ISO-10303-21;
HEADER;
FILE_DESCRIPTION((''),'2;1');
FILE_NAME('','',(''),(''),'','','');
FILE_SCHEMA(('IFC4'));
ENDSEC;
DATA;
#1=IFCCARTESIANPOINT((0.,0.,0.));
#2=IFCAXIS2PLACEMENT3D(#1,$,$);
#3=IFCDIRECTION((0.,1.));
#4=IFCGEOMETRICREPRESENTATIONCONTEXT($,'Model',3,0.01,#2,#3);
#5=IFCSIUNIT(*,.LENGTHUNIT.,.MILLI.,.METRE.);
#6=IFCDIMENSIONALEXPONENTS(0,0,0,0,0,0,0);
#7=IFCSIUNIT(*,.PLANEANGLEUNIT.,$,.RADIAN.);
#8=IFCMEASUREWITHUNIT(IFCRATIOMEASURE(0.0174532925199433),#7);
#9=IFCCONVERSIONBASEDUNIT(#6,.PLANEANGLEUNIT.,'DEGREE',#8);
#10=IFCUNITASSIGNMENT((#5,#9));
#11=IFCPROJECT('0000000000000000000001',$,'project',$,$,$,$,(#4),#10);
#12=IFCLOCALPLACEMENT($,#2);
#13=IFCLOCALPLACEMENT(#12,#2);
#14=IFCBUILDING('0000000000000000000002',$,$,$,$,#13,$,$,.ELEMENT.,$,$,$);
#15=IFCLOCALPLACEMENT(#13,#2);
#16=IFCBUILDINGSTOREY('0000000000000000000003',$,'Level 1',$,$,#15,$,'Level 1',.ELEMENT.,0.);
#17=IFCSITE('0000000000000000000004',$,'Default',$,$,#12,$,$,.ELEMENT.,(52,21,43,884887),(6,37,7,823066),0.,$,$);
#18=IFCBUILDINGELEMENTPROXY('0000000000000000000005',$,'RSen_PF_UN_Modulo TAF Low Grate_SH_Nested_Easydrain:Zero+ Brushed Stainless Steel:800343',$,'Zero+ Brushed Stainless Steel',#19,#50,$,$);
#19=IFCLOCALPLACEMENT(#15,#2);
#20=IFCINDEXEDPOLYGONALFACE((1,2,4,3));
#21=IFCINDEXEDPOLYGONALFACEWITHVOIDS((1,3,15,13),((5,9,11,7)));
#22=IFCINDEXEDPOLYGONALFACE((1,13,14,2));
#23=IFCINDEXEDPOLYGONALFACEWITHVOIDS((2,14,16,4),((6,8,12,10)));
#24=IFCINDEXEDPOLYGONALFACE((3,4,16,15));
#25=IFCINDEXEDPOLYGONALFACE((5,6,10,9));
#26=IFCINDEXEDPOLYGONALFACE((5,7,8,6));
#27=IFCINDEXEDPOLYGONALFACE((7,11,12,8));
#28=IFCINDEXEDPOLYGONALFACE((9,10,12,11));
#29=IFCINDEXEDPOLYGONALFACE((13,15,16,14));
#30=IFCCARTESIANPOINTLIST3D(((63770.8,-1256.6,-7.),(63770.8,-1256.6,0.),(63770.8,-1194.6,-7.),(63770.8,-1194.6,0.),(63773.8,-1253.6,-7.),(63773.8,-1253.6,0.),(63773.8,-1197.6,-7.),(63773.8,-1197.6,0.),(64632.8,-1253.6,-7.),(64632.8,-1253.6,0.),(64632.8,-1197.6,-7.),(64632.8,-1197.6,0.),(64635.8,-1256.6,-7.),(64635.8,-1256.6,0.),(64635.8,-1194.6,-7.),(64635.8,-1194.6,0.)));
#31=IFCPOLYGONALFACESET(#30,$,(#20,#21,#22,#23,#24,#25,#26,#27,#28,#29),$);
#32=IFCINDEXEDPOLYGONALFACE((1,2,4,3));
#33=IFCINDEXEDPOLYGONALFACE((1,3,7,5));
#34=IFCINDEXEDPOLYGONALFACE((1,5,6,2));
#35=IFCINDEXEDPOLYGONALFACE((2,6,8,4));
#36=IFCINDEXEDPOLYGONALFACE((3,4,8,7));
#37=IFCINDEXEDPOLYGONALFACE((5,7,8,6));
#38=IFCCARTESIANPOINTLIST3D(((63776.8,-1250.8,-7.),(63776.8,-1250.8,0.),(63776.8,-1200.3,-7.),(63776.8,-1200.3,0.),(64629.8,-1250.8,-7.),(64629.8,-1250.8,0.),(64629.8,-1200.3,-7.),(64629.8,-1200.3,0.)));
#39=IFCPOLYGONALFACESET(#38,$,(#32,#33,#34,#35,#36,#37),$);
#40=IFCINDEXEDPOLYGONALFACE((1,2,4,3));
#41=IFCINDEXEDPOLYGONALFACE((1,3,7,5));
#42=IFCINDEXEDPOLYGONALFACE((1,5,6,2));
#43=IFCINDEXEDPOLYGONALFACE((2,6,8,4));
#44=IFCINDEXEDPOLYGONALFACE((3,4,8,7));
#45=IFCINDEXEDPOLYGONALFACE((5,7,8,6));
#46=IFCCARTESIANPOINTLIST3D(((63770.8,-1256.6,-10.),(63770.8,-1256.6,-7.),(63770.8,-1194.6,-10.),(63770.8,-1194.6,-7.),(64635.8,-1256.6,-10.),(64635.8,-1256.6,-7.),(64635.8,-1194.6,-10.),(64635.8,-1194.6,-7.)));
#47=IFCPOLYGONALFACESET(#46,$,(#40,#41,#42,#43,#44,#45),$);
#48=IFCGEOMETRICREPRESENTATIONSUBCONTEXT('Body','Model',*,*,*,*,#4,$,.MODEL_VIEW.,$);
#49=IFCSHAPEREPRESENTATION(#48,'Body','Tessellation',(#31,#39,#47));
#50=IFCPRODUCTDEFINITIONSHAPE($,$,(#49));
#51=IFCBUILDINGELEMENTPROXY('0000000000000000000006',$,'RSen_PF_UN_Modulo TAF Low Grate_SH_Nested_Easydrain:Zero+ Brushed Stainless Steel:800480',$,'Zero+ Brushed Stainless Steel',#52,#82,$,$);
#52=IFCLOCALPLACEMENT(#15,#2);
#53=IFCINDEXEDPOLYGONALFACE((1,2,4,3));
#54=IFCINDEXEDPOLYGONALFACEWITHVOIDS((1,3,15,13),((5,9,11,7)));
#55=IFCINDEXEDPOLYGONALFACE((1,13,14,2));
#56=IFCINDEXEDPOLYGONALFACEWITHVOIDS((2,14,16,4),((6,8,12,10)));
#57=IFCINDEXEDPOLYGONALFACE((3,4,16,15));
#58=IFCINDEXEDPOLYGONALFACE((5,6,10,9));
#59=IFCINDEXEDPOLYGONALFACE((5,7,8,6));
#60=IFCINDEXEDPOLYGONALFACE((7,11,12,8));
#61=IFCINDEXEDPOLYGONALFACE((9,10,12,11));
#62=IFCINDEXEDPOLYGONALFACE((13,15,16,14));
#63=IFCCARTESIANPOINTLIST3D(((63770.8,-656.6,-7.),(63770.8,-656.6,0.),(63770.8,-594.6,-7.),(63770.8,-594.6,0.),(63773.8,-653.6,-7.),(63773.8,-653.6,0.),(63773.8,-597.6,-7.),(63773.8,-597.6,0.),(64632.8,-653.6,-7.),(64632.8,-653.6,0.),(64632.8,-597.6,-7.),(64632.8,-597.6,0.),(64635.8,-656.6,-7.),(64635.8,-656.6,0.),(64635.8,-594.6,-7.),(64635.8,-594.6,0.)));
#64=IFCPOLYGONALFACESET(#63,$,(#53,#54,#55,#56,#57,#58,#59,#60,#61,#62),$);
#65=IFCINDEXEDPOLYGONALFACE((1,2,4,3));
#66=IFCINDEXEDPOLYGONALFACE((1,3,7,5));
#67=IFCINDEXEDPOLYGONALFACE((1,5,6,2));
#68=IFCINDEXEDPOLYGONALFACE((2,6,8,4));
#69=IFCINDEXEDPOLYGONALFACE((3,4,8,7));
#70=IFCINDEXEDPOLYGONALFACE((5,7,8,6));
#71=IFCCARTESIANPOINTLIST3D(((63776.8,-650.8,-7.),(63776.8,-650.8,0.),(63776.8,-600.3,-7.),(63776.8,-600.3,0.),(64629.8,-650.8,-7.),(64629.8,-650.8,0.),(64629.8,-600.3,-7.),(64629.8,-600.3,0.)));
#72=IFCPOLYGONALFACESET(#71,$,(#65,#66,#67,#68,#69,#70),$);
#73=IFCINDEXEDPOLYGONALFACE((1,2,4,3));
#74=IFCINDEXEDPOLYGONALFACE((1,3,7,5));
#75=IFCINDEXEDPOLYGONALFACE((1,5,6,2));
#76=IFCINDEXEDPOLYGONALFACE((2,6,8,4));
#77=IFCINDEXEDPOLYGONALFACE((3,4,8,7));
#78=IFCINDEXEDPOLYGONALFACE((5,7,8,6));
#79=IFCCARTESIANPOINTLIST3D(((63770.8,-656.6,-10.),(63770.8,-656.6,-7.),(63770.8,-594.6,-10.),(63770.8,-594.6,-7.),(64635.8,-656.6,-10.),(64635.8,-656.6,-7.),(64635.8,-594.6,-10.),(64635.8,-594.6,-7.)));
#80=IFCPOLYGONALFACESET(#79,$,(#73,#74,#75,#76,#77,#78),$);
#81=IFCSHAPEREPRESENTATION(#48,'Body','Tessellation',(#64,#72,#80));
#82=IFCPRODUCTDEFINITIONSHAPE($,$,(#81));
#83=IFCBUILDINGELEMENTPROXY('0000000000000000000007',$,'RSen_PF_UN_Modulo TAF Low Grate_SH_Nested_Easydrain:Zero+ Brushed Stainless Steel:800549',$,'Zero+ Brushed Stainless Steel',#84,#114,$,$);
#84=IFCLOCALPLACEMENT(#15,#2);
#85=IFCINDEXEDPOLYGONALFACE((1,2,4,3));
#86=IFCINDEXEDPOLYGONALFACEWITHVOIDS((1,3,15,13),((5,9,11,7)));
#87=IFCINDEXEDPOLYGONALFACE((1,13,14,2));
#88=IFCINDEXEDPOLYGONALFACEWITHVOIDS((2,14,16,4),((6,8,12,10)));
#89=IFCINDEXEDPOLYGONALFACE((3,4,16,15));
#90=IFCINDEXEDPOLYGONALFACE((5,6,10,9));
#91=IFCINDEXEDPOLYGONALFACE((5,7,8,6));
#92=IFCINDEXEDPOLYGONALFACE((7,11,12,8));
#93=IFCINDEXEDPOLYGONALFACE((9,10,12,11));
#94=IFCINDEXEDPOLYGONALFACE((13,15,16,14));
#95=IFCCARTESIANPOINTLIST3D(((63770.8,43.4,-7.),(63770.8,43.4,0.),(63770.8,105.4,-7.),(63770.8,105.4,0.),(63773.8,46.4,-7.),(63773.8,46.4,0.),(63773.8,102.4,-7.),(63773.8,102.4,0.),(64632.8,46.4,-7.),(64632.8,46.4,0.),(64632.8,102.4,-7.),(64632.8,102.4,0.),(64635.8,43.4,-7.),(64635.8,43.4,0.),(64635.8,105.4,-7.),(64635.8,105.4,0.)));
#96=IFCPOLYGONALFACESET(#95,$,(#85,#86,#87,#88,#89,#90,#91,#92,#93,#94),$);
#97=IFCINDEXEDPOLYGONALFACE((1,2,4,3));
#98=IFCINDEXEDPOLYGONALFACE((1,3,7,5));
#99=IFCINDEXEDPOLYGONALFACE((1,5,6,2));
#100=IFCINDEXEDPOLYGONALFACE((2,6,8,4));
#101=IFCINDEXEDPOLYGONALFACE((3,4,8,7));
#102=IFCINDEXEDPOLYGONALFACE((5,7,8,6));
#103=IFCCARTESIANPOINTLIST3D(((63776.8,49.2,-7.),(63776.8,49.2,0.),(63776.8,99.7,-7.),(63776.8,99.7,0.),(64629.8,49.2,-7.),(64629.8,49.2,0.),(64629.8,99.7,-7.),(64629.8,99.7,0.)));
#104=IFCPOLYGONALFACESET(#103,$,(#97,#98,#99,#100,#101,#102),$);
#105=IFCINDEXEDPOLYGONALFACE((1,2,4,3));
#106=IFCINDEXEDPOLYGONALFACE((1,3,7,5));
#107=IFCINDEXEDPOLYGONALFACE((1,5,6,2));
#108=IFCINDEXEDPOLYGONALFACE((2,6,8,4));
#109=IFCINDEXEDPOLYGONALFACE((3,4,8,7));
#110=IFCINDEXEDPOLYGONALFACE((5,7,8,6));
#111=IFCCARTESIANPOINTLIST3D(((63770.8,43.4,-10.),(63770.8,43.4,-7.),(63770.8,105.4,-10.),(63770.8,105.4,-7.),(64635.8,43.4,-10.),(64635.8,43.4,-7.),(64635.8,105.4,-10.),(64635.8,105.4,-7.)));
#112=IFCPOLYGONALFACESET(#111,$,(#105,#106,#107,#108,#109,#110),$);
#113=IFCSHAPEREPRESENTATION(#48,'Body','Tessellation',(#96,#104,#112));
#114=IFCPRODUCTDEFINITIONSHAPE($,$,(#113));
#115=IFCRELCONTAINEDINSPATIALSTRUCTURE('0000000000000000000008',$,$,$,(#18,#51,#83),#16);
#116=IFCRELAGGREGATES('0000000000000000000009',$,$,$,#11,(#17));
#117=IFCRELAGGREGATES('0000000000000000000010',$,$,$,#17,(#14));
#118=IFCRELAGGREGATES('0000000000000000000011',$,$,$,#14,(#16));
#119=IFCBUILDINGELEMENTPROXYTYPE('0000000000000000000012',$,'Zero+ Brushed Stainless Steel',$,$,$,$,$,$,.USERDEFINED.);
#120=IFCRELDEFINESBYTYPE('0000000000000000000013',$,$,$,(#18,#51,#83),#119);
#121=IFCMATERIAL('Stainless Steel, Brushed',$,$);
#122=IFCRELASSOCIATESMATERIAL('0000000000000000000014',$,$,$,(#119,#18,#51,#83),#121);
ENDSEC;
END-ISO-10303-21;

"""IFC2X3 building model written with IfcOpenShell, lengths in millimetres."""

from ifc_helpers import new_model, entity, si_unit, converted_unit, direction, frame, frame_2d, origin, origin_2d_with_axis, place, context, subcontext, project, spatial, polyline, rectangle, outline, extrude, source, transform, mapped, material, type_object, type_shapes, element, save


model = new_model("IFC2X3")

# Units and contexts
model_context = context("Model", 3, precision=0.01, world=origin(), true_north=direction((0.0, 1.0)))
body_context = subcontext(model_context, "Body", "Model", "MODEL_VIEW")
ifc_project = project(units=[si_unit("LENGTHUNIT", "METRE", prefix="MILLI"), converted_unit("PLANEANGLEUNIT", "DEGREE", entity("IfcRatioMeasure", 0.0174532925199433), si_unit("PLANEANGLEUNIT", "RADIAN"), dimensions=[0, 0, 0, 0, 0, 0, 0])], contexts=[model_context])

# Site, building, storey
site_placement = place(None, origin())
site = spatial("IfcSite", under=ifc_project, at=site_placement, Name="Default", CompositionType="ELEMENT", RefLatitude=(52, 21, 43, 884887), RefLongitude=(6, 37, 7, 823066), RefElevation=0.0)
building_placement = place(site_placement, origin())
building = spatial("IfcBuilding", under=site, at=building_placement, CompositionType="ELEMENT")
storey_placement = place(building_placement, origin())
storey = spatial("IfcBuildingStorey", under=building, at=storey_placement, Name="Level 1", LongName="Level 1", CompositionType="ELEMENT", Elevation=0.0)

# Shared definitions
ifc_material_1 = material(Name="Stainless Steel, Brushed")

# Building element proxies
building_element_proxy_type_1 = type_object("IfcBuildingElementProxyType", Name="Zero+ Brushed Stainless Steel", PredefinedType="USERDEFINED", material=ifc_material_1)
shared_shape_1 = source(origin(), body_context, "Body", "SweptSolid", [
    extrude(outline(polyline([(-432.5, -31.0), (432.5, -31.0), (432.5, 31.0), (-432.5, 31.0), (-432.5, -31.0)]), holes=[polyline([(-429.5, -28.0), (-429.5, 28.0), (429.5, 28.0), (429.5, -28.0), (-429.5, -28.0)])]), frame((0.0, 0.0, 0.0), z_axis=(0.0, 0.0, 1.0), x_axis=(-1.0, 0.0, 0.0)), (0.0, 0.0, 1.0), 7.0),
    extrude(rectangle(XDim=853.0, YDim=50.5, at=frame_2d((0.0, 0.0), x_axis=(1.0, 0.0))), frame((0.0, 0.0, 0.0), z_axis=(0.0, 0.0, 1.0), x_axis=(-1.0, 0.0, 0.0)), (0.0, 0.0, 1.0), 7.0),
    extrude(rectangle(XDim=865.0, YDim=62.0, at=origin_2d_with_axis()), frame((0.0, 0.0, -3.0), z_axis=(0.0, 0.0, 1.0), x_axis=(-1.0, 0.0, 0.0)), (0.0, 0.0, 1.0), 3.0),
])
type_shapes(building_element_proxy_type_1, [shared_shape_1])
for number, where, name in (
    (1, (64203.3, -1225.6, -7.0), "RSen_PF_UN_Modulo TAF Low Grate_SH_Nested_Easydrain:Zero+ Brushed Stainless Steel:800343"),
    (2, (64203.3, -625.6, -7.0), "RSen_PF_UN_Modulo TAF Low Grate_SH_Nested_Easydrain:Zero+ Brushed Stainless Steel:800480"),
    (3, (64203.3, 74.4, -7.0), "RSen_PF_UN_Modulo TAF Low Grate_SH_Nested_Easydrain:Zero+ Brushed Stainless Steel:800549"),
):
    element("IfcBuildingElementProxy", number, at=place(storey_placement, frame(where)), inside=storey, type_object=building_element_proxy_type_1, material=ifc_material_1, Name=name, ObjectType="Zero+ Brushed Stainless Steel", context=body_context, shape_type="MappedRepresentation", body=[
        mapped(shared_shape_1, transform((0.0, 0.0, 0.0), scale=1.0)),
    ])

save(model, "model.ifc")
